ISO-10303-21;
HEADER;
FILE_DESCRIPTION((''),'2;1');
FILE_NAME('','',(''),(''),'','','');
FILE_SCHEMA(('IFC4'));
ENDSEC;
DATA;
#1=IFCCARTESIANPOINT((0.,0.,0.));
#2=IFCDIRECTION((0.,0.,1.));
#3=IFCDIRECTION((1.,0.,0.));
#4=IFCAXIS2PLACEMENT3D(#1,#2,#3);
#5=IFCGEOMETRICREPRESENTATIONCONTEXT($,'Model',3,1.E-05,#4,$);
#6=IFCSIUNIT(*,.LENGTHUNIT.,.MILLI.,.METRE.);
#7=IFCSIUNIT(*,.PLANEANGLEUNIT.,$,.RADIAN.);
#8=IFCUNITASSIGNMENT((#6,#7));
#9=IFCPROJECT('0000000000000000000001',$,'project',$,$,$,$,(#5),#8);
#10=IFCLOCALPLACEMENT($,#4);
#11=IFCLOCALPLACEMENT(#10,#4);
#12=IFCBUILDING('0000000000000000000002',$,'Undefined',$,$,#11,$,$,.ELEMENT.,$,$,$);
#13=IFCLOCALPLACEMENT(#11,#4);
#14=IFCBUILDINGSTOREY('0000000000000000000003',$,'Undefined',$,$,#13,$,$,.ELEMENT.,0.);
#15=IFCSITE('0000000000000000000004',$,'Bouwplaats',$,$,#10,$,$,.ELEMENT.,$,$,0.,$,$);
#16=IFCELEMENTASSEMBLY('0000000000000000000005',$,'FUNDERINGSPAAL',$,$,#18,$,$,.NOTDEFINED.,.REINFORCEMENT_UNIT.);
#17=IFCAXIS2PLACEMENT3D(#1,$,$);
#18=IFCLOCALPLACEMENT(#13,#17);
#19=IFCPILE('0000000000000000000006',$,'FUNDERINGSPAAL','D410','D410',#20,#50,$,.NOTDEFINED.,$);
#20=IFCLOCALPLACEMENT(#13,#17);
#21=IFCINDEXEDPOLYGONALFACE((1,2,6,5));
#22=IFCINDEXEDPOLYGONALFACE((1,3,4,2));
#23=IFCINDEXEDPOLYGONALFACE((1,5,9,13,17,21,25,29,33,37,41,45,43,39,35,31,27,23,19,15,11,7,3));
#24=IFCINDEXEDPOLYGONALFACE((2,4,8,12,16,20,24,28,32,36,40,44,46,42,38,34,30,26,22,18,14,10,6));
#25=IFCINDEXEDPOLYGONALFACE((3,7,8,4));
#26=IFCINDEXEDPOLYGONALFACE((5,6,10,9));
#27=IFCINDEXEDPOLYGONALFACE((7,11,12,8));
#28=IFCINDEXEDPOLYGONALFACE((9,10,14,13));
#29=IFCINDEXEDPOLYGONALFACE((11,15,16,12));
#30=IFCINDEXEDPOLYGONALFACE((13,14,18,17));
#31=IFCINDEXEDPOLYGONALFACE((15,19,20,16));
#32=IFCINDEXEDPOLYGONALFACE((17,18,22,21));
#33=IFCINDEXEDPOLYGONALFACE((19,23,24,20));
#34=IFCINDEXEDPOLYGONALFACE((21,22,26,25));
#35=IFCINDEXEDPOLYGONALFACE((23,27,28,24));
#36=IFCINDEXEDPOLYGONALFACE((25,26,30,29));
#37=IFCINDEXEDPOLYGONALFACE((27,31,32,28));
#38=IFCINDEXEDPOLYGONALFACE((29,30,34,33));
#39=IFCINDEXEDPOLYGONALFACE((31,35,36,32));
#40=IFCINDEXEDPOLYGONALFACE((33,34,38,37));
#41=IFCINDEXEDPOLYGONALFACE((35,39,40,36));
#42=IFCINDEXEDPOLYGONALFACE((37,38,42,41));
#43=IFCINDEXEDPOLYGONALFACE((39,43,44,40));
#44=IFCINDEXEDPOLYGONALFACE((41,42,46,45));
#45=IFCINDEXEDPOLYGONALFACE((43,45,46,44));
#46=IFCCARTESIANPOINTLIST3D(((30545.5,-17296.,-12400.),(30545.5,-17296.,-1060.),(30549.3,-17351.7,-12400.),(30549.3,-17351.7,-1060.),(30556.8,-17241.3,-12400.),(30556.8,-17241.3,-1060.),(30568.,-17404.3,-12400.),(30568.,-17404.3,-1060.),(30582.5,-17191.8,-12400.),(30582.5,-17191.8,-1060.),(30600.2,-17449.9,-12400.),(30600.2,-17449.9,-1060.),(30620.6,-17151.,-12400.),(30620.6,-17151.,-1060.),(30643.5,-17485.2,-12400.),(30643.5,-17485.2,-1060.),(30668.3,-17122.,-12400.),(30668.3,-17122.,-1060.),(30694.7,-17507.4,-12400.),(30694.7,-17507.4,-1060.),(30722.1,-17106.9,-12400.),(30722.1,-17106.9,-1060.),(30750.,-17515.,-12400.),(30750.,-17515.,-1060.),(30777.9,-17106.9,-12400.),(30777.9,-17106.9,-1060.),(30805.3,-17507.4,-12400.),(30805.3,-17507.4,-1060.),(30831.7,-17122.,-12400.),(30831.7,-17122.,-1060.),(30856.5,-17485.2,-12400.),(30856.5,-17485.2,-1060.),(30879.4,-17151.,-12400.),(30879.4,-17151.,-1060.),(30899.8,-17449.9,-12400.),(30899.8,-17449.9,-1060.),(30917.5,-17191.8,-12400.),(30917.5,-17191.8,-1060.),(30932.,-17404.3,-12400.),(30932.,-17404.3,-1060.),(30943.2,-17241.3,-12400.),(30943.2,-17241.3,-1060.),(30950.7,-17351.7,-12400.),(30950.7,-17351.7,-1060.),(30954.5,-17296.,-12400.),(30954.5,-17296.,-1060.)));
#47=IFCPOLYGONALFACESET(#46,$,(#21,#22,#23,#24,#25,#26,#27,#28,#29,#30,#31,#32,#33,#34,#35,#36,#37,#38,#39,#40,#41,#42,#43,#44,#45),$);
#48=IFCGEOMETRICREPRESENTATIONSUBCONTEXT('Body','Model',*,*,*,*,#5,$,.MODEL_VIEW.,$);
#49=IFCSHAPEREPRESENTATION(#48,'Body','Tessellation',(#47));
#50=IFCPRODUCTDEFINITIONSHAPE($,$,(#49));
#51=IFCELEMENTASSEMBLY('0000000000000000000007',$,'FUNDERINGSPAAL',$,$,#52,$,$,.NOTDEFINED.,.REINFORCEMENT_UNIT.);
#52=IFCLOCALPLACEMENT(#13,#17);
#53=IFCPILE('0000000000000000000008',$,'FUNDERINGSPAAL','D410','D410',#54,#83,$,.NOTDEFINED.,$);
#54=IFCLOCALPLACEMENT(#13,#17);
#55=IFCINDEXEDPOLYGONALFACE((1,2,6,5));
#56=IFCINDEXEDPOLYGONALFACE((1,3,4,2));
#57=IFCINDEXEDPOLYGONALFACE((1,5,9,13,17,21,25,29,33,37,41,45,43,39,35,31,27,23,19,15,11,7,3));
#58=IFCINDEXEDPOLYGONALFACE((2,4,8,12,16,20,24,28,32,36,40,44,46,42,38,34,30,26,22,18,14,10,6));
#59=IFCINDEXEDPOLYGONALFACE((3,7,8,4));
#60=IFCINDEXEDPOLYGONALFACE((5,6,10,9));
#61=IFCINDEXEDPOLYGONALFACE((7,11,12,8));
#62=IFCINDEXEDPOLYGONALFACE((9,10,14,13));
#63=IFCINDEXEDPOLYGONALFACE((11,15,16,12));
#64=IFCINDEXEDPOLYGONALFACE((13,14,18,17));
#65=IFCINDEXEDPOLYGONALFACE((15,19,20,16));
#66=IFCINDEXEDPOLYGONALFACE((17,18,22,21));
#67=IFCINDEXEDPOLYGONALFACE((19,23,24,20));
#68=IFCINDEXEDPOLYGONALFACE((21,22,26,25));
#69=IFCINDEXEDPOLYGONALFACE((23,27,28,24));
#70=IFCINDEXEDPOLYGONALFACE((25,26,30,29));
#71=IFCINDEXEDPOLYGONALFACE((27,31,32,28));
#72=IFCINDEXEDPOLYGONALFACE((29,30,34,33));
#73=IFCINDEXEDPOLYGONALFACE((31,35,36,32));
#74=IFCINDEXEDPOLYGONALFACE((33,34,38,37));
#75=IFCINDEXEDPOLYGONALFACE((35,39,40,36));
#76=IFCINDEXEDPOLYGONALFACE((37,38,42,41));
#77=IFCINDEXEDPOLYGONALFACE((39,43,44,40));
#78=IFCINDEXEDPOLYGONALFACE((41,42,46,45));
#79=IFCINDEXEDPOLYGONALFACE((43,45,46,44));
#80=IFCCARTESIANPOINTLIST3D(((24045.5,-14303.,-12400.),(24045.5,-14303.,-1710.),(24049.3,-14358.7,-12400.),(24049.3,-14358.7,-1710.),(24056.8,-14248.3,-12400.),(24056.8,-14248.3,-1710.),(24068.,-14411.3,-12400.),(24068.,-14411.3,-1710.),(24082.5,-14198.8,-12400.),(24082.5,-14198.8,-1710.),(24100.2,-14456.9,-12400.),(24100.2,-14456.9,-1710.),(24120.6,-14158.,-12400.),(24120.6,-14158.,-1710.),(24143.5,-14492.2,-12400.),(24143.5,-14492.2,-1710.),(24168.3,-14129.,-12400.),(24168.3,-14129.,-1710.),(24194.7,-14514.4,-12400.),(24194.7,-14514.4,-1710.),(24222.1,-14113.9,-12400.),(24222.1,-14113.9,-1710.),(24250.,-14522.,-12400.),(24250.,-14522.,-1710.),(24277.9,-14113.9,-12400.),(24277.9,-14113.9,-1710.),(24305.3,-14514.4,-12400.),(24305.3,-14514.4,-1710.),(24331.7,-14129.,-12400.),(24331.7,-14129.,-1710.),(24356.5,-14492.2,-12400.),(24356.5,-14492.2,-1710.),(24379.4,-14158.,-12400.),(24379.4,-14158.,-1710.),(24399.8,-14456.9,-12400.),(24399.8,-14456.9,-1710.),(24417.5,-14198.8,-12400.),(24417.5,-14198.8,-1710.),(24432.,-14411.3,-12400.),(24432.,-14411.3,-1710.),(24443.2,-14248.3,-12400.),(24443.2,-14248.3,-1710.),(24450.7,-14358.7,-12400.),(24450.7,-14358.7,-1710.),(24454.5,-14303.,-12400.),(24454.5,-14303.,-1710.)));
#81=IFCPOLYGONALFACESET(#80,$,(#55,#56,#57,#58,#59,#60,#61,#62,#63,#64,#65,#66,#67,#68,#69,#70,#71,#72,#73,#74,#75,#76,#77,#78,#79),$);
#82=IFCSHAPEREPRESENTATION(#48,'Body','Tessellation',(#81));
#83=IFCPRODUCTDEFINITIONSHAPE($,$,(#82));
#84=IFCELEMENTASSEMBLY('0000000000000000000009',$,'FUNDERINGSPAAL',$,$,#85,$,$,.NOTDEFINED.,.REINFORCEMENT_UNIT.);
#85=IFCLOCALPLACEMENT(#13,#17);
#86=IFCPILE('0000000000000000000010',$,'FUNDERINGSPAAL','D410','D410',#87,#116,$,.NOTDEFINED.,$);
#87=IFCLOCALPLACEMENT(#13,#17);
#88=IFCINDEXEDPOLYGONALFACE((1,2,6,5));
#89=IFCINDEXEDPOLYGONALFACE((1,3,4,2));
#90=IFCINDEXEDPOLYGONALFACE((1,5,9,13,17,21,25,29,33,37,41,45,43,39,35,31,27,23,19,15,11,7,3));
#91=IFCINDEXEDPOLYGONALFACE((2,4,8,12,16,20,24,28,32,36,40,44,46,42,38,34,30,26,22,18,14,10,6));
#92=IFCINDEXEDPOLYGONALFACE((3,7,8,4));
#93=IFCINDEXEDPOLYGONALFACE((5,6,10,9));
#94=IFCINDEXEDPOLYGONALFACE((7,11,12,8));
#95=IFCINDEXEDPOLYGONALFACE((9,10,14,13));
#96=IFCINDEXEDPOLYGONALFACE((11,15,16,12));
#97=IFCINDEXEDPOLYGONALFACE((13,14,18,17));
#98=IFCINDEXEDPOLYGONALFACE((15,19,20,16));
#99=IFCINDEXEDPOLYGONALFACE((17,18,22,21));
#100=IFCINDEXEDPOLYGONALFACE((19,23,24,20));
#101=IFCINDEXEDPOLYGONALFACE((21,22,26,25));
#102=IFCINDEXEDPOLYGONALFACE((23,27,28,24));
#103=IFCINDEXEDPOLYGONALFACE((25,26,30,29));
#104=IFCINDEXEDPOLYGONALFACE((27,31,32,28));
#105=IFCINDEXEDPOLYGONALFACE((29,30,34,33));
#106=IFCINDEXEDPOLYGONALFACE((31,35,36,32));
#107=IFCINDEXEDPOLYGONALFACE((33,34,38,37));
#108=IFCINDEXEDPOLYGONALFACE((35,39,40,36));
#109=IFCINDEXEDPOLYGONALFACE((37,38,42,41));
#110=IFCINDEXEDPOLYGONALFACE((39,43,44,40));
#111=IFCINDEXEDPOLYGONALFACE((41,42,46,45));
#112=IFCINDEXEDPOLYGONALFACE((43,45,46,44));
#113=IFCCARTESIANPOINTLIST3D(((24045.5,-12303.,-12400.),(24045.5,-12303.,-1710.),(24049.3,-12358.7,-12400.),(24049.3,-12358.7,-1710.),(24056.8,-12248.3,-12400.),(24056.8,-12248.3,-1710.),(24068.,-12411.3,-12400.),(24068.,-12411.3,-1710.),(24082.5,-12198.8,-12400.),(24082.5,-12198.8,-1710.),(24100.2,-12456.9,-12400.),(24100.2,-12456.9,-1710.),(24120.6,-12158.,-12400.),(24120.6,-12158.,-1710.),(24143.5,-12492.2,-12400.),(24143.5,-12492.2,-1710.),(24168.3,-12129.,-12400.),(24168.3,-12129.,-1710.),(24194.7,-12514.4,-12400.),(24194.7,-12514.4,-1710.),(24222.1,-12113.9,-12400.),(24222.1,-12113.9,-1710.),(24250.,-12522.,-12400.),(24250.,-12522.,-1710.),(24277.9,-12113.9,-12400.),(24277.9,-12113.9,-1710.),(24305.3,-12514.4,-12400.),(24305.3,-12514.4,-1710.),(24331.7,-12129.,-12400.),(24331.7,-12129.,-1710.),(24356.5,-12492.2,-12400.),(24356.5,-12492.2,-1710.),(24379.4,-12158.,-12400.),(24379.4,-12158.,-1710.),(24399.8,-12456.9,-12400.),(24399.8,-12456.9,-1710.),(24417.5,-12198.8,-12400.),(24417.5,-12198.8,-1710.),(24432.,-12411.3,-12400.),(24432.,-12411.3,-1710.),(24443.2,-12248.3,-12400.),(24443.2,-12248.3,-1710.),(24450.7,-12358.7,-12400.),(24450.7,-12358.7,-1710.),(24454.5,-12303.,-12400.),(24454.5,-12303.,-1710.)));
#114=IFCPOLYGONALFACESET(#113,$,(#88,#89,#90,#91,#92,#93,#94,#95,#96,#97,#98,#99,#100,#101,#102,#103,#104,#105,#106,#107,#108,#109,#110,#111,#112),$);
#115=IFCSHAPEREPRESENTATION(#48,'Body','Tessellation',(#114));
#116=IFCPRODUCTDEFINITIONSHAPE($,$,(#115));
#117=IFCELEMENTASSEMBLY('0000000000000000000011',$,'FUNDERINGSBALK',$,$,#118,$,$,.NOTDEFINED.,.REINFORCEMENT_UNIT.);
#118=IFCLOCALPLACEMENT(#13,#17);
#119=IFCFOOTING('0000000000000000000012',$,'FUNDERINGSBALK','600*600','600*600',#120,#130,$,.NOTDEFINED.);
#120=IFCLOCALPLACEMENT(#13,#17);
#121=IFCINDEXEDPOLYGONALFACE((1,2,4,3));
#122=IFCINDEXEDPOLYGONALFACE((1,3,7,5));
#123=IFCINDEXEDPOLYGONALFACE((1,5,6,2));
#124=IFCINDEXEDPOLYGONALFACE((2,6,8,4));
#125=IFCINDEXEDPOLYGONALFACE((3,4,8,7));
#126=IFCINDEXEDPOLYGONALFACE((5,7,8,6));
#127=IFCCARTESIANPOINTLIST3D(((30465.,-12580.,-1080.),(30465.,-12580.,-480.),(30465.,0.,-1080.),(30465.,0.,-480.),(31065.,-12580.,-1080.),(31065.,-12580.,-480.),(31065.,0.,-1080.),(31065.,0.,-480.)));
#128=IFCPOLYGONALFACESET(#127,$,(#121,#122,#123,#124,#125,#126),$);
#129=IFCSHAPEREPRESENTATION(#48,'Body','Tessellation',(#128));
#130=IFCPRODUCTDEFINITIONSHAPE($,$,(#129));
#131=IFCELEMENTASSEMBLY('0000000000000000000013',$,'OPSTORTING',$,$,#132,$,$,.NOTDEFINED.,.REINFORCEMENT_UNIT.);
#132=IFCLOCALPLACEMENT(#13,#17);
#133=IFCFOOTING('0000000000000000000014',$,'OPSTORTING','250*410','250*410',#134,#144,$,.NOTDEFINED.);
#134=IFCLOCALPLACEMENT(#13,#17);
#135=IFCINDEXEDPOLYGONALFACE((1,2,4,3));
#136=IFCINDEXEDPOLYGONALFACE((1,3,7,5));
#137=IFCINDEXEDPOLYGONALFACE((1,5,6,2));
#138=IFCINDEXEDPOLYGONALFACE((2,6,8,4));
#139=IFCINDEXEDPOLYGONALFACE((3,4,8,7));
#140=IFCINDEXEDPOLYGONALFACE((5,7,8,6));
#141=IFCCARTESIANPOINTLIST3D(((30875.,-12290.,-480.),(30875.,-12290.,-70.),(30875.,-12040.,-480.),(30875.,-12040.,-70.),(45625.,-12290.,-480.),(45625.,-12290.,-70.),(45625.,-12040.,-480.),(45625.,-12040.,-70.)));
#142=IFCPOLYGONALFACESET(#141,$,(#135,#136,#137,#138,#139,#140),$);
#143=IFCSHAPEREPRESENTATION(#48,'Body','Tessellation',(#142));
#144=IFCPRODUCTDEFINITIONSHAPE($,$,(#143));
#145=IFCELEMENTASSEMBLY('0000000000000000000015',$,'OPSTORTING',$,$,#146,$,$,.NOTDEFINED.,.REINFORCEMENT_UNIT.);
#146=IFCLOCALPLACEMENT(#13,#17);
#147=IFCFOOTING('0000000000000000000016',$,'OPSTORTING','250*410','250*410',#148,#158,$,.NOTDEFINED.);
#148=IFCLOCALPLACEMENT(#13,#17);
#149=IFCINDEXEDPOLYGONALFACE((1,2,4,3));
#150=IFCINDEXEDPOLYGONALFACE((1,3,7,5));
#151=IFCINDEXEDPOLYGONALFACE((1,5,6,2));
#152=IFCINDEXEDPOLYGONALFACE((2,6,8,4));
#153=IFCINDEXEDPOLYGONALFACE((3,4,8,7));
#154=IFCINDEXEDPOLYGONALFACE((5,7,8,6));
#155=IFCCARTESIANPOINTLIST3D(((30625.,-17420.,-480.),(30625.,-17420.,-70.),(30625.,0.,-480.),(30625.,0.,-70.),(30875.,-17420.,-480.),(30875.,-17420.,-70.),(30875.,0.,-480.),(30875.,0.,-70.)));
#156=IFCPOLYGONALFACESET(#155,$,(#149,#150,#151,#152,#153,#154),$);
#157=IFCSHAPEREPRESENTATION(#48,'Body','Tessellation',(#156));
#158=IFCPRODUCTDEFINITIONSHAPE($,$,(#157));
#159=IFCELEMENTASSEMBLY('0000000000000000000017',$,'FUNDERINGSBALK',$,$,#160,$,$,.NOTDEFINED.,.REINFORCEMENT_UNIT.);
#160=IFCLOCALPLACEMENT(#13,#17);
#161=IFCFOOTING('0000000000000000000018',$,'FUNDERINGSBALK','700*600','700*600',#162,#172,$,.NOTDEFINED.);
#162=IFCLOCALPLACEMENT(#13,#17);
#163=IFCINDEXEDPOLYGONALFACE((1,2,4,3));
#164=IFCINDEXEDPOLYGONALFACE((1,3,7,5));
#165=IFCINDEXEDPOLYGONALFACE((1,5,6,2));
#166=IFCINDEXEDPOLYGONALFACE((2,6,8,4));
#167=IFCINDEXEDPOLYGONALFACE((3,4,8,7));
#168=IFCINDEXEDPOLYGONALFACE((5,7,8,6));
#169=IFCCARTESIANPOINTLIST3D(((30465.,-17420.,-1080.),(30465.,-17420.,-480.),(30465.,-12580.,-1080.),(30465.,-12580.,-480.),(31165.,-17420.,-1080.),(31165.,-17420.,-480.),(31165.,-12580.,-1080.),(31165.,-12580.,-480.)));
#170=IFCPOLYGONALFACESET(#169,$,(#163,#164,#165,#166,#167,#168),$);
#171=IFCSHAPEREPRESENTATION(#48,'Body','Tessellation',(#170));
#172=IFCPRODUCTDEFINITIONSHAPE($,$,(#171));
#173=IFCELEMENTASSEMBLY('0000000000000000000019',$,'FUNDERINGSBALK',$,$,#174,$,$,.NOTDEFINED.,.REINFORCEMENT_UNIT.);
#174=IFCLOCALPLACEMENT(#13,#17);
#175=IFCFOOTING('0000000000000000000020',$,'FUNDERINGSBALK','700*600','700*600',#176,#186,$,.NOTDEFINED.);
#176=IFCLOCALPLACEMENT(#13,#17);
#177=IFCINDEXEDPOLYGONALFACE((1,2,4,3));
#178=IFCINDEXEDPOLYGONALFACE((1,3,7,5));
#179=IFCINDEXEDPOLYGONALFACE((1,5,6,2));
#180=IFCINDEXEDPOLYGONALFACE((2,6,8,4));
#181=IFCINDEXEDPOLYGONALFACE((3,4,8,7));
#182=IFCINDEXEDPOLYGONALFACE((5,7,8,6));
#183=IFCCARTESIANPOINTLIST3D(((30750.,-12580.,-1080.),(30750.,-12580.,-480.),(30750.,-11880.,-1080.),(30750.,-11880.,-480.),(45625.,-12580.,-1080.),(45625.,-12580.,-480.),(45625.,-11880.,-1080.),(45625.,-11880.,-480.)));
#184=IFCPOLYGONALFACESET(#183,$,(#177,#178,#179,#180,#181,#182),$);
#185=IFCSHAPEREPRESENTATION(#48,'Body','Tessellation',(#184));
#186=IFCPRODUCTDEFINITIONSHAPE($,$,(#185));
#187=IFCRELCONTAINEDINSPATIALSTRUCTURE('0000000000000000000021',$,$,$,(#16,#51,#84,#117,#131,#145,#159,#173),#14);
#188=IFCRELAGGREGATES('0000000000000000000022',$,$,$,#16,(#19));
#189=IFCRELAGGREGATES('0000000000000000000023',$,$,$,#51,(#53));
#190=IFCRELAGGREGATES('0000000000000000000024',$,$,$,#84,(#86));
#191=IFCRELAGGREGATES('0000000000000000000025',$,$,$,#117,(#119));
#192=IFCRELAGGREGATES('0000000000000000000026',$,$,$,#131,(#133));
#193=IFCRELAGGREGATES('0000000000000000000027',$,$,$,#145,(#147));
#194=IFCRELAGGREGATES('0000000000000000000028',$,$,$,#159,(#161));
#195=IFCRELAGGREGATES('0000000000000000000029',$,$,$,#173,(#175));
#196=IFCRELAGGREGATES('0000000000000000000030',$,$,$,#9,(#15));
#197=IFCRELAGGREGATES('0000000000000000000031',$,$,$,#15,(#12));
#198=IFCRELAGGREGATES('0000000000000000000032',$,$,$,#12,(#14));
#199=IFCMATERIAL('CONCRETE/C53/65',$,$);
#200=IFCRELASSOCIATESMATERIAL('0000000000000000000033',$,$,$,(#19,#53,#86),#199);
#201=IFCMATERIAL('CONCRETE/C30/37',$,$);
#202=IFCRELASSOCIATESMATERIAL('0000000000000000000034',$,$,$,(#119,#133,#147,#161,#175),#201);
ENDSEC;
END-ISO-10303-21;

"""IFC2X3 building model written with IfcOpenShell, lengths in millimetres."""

from ifc_helpers import new_model, si_unit, frame, origin_with_axes, origin_2d_with_axis, place, context, subcontext, project, spatial, rectangle, circle, extrude, clip, halfspace, material, element, aggregate, save


model = new_model("IFC2X3")

# Units and contexts
model_context = context("Model", 3, precision=1e-05, world=origin_with_axes())
body_context = subcontext(model_context, "Body", "Model", "MODEL_VIEW")
ifc_project = project(units=[si_unit("LENGTHUNIT", "METRE", prefix="MILLI"), si_unit("PLANEANGLEUNIT", "RADIAN")], contexts=[model_context])

# Site, building, storey
site_placement = place(None, origin_with_axes())
site = spatial("IfcSite", under=ifc_project, at=site_placement, Name="Bouwplaats", CompositionType="ELEMENT", RefElevation=0.0)
building_placement = place(site_placement, origin_with_axes())
building = spatial("IfcBuilding", under=site, at=building_placement, Name="Undefined", CompositionType="ELEMENT")
storey_placement = place(building_placement, origin_with_axes())
storey = spatial("IfcBuildingStorey", under=building, at=storey_placement, Name="Undefined", CompositionType="ELEMENT", Elevation=0.0)

# Element assemblies, piles
ifc_material_1 = material(Name="CONCRETE/C53/65")
assembly_1_placement = place(storey_placement, origin_with_axes())
assembly_1 = element("IfcElementAssembly", 1, at=assembly_1_placement, inside=storey, Name="FUNDERINGSPAAL", AssemblyPlace="NOTDEFINED", PredefinedType="REINFORCEMENT_UNIT")
pile_1_placement = place(assembly_1_placement, frame((30750.0, -17310.0, -1060.0), z_axis=(1.0, 0.0, 0.0), x_axis=(0.0, 0.0, -1.0)))
pile_1 = element("IfcPile", 2, at=pile_1_placement, material=ifc_material_1, Name="FUNDERINGSPAAL", Description="D410", ObjectType="D410", PredefinedType="NOTDEFINED", context=body_context, shape_type="Clipping", body=[
    clip(extrude(circle(Radius=205.0, at=origin_2d_with_axis()), frame((11340.0, 0.0, 0.0), z_axis=(-1.0, 0.0, 0.0), x_axis=(0.0, -1.0, 0.0)), (0.0, 0.0, 1.0), 11340.0), halfspace(frame((0.0, 205.0, -205.0), z_axis=(-1.0, 0.0, 0.0), x_axis=(0.0, 0.0, 1.0)), False)),
])
aggregate(assembly_1, [pile_1])
assembly_2_placement = place(storey_placement, origin_with_axes())
assembly_2 = element("IfcElementAssembly", 3, at=assembly_2_placement, inside=storey, Name="FUNDERINGSPAAL", AssemblyPlace="NOTDEFINED", PredefinedType="REINFORCEMENT_UNIT")
pile_2_placement = place(assembly_2_placement, frame((24250.0, -14317.0, -1710.0), z_axis=(1.0, 0.0, 0.0), x_axis=(0.0, 0.0, -1.0)))
pile_2 = element("IfcPile", 4, at=pile_2_placement, material=ifc_material_1, Name="FUNDERINGSPAAL", Description="D410", ObjectType="D410", PredefinedType="NOTDEFINED", context=body_context, shape_type="Clipping", body=[
    clip(extrude(circle(Radius=205.0, at=origin_2d_with_axis()), frame((10690.0, 0.0, 0.0), z_axis=(-1.0, 0.0, 0.0), x_axis=(0.0, -1.0, 0.0)), (0.0, 0.0, 1.0), 10690.0), halfspace(frame((0.0, 205.0, -205.0), z_axis=(-1.0, 0.0, 0.0), x_axis=(0.0, 0.0, 1.0)), False)),
])
aggregate(assembly_2, [pile_2])
assembly_3_placement = place(storey_placement, origin_with_axes())
assembly_3 = element("IfcElementAssembly", 5, at=assembly_3_placement, inside=storey, Name="FUNDERINGSPAAL", AssemblyPlace="NOTDEFINED", PredefinedType="REINFORCEMENT_UNIT")
pile_3_placement = place(assembly_3_placement, frame((24250.0, -12317.0, -1710.0), z_axis=(1.0, 0.0, 0.0), x_axis=(0.0, 0.0, -1.0)))
pile_3 = element("IfcPile", 6, at=pile_3_placement, material=ifc_material_1, Name="FUNDERINGSPAAL", Description="D410", ObjectType="D410", PredefinedType="NOTDEFINED", context=body_context, shape_type="Clipping", body=[
    clip(extrude(circle(Radius=205.0, at=origin_2d_with_axis()), frame((10690.0, 0.0, 0.0), z_axis=(-1.0, 0.0, 0.0), x_axis=(0.0, -1.0, 0.0)), (0.0, 0.0, 1.0), 10690.0), halfspace(frame((0.0, 205.0, -205.0), z_axis=(-1.0, 0.0, 0.0), x_axis=(0.0, 0.0, 1.0)), False)),
])
aggregate(assembly_3, [pile_3])

# Element assemblies, footings
assembly_4_placement = place(storey_placement, origin_with_axes())
assembly_4 = element("IfcElementAssembly", 7, at=assembly_4_placement, inside=storey, Name="FUNDERINGSBALK", AssemblyPlace="NOTDEFINED", PredefinedType="REINFORCEMENT_UNIT")
ifc_material_2 = material(Name="CONCRETE/C30/37")
footing_1_placement = place(assembly_4_placement, frame((30765.0, -12580.0, -780.0), z_axis=(0.0, 0.0, 1.0), x_axis=(0.0, 1.0, 0.0)))
footing_1 = element("IfcFooting", 8, at=footing_1_placement, material=ifc_material_2, Name="FUNDERINGSBALK", Description="600*600", ObjectType="600*600", PredefinedType="NOTDEFINED", context=body_context, shape_type="SweptSolid", body=[
    extrude(rectangle(XDim=600.0, YDim=600.0, at=origin_2d_with_axis()), frame((12580.0, 0.0, 0.0), z_axis=(-1.0, 0.0, 0.0), x_axis=(0.0, -1.0, 0.0)), (0.0, 0.0, 1.0), 12580.0),
])
aggregate(assembly_4, [footing_1])
assembly_5_placement = place(storey_placement, origin_with_axes())
assembly_5 = element("IfcElementAssembly", 9, at=assembly_5_placement, inside=storey, Name="OPSTORTING", AssemblyPlace="NOTDEFINED", PredefinedType="REINFORCEMENT_UNIT")
footing_2_placement = place(assembly_5_placement, frame((30875.0, -12165.0, -275.0), z_axis=(0.0, 0.0, 1.0), x_axis=(1.0, 0.0, 0.0)))
footing_2 = element("IfcFooting", 10, at=footing_2_placement, material=ifc_material_2, Name="OPSTORTING", Description="250*410", ObjectType="250*410", PredefinedType="NOTDEFINED", context=body_context, shape_type="SweptSolid", body=[
    extrude(rectangle(XDim=250.0, YDim=410.0, at=origin_2d_with_axis()), frame((14750.0, 0.0, 0.0), z_axis=(-1.0, 0.0, 0.0), x_axis=(0.0, -1.0, 0.0)), (0.0, 0.0, 1.0), 14750.0),
])
aggregate(assembly_5, [footing_2])
assembly_6_placement = place(storey_placement, origin_with_axes())
assembly_6 = element("IfcElementAssembly", 11, at=assembly_6_placement, inside=storey, Name="OPSTORTING", AssemblyPlace="NOTDEFINED", PredefinedType="REINFORCEMENT_UNIT")
footing_3_placement = place(assembly_6_placement, frame((30750.0, -17420.0, -275.0), z_axis=(0.0, 0.0, 1.0), x_axis=(0.0, 1.0, 0.0)))
footing_3 = element("IfcFooting", 12, at=footing_3_placement, material=ifc_material_2, Name="OPSTORTING", Description="250*410", ObjectType="250*410", PredefinedType="NOTDEFINED", context=body_context, shape_type="SweptSolid", body=[
    extrude(rectangle(XDim=250.0, YDim=410.0, at=origin_2d_with_axis()), frame((17420.0, 0.0, 0.0), z_axis=(-1.0, 0.0, 0.0), x_axis=(0.0, -1.0, 0.0)), (0.0, 0.0, 1.0), 17420.0),
])
aggregate(assembly_6, [footing_3])
assembly_7_placement = place(storey_placement, origin_with_axes())
assembly_7 = element("IfcElementAssembly", 13, at=assembly_7_placement, inside=storey, Name="FUNDERINGSBALK", AssemblyPlace="NOTDEFINED", PredefinedType="REINFORCEMENT_UNIT")
footing_4_placement = place(assembly_7_placement, frame((30815.0, -17420.0, -780.0), z_axis=(0.0, 0.0, 1.0), x_axis=(0.0, 1.0, 0.0)))
footing_4 = element("IfcFooting", 14, at=footing_4_placement, material=ifc_material_2, Name="FUNDERINGSBALK", Description="700*600", ObjectType="700*600", PredefinedType="NOTDEFINED", context=body_context, shape_type="SweptSolid", body=[
    extrude(rectangle(XDim=700.0, YDim=600.0, at=origin_2d_with_axis()), frame((4840.0, 0.0, 0.0), z_axis=(-1.0, 0.0, 0.0), x_axis=(0.0, -1.0, 0.0)), (0.0, 0.0, 1.0), 4840.0),
])
aggregate(assembly_7, [footing_4])
assembly_8_placement = place(storey_placement, origin_with_axes())
assembly_8 = element("IfcElementAssembly", 15, at=assembly_8_placement, inside=storey, Name="FUNDERINGSBALK", AssemblyPlace="NOTDEFINED", PredefinedType="REINFORCEMENT_UNIT")
footing_5_placement = place(assembly_8_placement, frame((30750.0, -12230.0, -780.0), z_axis=(0.0, 0.0, 1.0), x_axis=(1.0, 0.0, 0.0)))
footing_5 = element("IfcFooting", 16, at=footing_5_placement, material=ifc_material_2, Name="FUNDERINGSBALK", Description="700*600", ObjectType="700*600", PredefinedType="NOTDEFINED", context=body_context, shape_type="SweptSolid", body=[
    extrude(rectangle(XDim=700.0, YDim=600.0, at=origin_2d_with_axis()), frame((14875.0, 0.0, 0.0), z_axis=(-1.0, 0.0, 0.0), x_axis=(0.0, -1.0, 0.0)), (0.0, 0.0, 1.0), 14875.0),
])
aggregate(assembly_8, [footing_5])

save(model, "model.ifc")
